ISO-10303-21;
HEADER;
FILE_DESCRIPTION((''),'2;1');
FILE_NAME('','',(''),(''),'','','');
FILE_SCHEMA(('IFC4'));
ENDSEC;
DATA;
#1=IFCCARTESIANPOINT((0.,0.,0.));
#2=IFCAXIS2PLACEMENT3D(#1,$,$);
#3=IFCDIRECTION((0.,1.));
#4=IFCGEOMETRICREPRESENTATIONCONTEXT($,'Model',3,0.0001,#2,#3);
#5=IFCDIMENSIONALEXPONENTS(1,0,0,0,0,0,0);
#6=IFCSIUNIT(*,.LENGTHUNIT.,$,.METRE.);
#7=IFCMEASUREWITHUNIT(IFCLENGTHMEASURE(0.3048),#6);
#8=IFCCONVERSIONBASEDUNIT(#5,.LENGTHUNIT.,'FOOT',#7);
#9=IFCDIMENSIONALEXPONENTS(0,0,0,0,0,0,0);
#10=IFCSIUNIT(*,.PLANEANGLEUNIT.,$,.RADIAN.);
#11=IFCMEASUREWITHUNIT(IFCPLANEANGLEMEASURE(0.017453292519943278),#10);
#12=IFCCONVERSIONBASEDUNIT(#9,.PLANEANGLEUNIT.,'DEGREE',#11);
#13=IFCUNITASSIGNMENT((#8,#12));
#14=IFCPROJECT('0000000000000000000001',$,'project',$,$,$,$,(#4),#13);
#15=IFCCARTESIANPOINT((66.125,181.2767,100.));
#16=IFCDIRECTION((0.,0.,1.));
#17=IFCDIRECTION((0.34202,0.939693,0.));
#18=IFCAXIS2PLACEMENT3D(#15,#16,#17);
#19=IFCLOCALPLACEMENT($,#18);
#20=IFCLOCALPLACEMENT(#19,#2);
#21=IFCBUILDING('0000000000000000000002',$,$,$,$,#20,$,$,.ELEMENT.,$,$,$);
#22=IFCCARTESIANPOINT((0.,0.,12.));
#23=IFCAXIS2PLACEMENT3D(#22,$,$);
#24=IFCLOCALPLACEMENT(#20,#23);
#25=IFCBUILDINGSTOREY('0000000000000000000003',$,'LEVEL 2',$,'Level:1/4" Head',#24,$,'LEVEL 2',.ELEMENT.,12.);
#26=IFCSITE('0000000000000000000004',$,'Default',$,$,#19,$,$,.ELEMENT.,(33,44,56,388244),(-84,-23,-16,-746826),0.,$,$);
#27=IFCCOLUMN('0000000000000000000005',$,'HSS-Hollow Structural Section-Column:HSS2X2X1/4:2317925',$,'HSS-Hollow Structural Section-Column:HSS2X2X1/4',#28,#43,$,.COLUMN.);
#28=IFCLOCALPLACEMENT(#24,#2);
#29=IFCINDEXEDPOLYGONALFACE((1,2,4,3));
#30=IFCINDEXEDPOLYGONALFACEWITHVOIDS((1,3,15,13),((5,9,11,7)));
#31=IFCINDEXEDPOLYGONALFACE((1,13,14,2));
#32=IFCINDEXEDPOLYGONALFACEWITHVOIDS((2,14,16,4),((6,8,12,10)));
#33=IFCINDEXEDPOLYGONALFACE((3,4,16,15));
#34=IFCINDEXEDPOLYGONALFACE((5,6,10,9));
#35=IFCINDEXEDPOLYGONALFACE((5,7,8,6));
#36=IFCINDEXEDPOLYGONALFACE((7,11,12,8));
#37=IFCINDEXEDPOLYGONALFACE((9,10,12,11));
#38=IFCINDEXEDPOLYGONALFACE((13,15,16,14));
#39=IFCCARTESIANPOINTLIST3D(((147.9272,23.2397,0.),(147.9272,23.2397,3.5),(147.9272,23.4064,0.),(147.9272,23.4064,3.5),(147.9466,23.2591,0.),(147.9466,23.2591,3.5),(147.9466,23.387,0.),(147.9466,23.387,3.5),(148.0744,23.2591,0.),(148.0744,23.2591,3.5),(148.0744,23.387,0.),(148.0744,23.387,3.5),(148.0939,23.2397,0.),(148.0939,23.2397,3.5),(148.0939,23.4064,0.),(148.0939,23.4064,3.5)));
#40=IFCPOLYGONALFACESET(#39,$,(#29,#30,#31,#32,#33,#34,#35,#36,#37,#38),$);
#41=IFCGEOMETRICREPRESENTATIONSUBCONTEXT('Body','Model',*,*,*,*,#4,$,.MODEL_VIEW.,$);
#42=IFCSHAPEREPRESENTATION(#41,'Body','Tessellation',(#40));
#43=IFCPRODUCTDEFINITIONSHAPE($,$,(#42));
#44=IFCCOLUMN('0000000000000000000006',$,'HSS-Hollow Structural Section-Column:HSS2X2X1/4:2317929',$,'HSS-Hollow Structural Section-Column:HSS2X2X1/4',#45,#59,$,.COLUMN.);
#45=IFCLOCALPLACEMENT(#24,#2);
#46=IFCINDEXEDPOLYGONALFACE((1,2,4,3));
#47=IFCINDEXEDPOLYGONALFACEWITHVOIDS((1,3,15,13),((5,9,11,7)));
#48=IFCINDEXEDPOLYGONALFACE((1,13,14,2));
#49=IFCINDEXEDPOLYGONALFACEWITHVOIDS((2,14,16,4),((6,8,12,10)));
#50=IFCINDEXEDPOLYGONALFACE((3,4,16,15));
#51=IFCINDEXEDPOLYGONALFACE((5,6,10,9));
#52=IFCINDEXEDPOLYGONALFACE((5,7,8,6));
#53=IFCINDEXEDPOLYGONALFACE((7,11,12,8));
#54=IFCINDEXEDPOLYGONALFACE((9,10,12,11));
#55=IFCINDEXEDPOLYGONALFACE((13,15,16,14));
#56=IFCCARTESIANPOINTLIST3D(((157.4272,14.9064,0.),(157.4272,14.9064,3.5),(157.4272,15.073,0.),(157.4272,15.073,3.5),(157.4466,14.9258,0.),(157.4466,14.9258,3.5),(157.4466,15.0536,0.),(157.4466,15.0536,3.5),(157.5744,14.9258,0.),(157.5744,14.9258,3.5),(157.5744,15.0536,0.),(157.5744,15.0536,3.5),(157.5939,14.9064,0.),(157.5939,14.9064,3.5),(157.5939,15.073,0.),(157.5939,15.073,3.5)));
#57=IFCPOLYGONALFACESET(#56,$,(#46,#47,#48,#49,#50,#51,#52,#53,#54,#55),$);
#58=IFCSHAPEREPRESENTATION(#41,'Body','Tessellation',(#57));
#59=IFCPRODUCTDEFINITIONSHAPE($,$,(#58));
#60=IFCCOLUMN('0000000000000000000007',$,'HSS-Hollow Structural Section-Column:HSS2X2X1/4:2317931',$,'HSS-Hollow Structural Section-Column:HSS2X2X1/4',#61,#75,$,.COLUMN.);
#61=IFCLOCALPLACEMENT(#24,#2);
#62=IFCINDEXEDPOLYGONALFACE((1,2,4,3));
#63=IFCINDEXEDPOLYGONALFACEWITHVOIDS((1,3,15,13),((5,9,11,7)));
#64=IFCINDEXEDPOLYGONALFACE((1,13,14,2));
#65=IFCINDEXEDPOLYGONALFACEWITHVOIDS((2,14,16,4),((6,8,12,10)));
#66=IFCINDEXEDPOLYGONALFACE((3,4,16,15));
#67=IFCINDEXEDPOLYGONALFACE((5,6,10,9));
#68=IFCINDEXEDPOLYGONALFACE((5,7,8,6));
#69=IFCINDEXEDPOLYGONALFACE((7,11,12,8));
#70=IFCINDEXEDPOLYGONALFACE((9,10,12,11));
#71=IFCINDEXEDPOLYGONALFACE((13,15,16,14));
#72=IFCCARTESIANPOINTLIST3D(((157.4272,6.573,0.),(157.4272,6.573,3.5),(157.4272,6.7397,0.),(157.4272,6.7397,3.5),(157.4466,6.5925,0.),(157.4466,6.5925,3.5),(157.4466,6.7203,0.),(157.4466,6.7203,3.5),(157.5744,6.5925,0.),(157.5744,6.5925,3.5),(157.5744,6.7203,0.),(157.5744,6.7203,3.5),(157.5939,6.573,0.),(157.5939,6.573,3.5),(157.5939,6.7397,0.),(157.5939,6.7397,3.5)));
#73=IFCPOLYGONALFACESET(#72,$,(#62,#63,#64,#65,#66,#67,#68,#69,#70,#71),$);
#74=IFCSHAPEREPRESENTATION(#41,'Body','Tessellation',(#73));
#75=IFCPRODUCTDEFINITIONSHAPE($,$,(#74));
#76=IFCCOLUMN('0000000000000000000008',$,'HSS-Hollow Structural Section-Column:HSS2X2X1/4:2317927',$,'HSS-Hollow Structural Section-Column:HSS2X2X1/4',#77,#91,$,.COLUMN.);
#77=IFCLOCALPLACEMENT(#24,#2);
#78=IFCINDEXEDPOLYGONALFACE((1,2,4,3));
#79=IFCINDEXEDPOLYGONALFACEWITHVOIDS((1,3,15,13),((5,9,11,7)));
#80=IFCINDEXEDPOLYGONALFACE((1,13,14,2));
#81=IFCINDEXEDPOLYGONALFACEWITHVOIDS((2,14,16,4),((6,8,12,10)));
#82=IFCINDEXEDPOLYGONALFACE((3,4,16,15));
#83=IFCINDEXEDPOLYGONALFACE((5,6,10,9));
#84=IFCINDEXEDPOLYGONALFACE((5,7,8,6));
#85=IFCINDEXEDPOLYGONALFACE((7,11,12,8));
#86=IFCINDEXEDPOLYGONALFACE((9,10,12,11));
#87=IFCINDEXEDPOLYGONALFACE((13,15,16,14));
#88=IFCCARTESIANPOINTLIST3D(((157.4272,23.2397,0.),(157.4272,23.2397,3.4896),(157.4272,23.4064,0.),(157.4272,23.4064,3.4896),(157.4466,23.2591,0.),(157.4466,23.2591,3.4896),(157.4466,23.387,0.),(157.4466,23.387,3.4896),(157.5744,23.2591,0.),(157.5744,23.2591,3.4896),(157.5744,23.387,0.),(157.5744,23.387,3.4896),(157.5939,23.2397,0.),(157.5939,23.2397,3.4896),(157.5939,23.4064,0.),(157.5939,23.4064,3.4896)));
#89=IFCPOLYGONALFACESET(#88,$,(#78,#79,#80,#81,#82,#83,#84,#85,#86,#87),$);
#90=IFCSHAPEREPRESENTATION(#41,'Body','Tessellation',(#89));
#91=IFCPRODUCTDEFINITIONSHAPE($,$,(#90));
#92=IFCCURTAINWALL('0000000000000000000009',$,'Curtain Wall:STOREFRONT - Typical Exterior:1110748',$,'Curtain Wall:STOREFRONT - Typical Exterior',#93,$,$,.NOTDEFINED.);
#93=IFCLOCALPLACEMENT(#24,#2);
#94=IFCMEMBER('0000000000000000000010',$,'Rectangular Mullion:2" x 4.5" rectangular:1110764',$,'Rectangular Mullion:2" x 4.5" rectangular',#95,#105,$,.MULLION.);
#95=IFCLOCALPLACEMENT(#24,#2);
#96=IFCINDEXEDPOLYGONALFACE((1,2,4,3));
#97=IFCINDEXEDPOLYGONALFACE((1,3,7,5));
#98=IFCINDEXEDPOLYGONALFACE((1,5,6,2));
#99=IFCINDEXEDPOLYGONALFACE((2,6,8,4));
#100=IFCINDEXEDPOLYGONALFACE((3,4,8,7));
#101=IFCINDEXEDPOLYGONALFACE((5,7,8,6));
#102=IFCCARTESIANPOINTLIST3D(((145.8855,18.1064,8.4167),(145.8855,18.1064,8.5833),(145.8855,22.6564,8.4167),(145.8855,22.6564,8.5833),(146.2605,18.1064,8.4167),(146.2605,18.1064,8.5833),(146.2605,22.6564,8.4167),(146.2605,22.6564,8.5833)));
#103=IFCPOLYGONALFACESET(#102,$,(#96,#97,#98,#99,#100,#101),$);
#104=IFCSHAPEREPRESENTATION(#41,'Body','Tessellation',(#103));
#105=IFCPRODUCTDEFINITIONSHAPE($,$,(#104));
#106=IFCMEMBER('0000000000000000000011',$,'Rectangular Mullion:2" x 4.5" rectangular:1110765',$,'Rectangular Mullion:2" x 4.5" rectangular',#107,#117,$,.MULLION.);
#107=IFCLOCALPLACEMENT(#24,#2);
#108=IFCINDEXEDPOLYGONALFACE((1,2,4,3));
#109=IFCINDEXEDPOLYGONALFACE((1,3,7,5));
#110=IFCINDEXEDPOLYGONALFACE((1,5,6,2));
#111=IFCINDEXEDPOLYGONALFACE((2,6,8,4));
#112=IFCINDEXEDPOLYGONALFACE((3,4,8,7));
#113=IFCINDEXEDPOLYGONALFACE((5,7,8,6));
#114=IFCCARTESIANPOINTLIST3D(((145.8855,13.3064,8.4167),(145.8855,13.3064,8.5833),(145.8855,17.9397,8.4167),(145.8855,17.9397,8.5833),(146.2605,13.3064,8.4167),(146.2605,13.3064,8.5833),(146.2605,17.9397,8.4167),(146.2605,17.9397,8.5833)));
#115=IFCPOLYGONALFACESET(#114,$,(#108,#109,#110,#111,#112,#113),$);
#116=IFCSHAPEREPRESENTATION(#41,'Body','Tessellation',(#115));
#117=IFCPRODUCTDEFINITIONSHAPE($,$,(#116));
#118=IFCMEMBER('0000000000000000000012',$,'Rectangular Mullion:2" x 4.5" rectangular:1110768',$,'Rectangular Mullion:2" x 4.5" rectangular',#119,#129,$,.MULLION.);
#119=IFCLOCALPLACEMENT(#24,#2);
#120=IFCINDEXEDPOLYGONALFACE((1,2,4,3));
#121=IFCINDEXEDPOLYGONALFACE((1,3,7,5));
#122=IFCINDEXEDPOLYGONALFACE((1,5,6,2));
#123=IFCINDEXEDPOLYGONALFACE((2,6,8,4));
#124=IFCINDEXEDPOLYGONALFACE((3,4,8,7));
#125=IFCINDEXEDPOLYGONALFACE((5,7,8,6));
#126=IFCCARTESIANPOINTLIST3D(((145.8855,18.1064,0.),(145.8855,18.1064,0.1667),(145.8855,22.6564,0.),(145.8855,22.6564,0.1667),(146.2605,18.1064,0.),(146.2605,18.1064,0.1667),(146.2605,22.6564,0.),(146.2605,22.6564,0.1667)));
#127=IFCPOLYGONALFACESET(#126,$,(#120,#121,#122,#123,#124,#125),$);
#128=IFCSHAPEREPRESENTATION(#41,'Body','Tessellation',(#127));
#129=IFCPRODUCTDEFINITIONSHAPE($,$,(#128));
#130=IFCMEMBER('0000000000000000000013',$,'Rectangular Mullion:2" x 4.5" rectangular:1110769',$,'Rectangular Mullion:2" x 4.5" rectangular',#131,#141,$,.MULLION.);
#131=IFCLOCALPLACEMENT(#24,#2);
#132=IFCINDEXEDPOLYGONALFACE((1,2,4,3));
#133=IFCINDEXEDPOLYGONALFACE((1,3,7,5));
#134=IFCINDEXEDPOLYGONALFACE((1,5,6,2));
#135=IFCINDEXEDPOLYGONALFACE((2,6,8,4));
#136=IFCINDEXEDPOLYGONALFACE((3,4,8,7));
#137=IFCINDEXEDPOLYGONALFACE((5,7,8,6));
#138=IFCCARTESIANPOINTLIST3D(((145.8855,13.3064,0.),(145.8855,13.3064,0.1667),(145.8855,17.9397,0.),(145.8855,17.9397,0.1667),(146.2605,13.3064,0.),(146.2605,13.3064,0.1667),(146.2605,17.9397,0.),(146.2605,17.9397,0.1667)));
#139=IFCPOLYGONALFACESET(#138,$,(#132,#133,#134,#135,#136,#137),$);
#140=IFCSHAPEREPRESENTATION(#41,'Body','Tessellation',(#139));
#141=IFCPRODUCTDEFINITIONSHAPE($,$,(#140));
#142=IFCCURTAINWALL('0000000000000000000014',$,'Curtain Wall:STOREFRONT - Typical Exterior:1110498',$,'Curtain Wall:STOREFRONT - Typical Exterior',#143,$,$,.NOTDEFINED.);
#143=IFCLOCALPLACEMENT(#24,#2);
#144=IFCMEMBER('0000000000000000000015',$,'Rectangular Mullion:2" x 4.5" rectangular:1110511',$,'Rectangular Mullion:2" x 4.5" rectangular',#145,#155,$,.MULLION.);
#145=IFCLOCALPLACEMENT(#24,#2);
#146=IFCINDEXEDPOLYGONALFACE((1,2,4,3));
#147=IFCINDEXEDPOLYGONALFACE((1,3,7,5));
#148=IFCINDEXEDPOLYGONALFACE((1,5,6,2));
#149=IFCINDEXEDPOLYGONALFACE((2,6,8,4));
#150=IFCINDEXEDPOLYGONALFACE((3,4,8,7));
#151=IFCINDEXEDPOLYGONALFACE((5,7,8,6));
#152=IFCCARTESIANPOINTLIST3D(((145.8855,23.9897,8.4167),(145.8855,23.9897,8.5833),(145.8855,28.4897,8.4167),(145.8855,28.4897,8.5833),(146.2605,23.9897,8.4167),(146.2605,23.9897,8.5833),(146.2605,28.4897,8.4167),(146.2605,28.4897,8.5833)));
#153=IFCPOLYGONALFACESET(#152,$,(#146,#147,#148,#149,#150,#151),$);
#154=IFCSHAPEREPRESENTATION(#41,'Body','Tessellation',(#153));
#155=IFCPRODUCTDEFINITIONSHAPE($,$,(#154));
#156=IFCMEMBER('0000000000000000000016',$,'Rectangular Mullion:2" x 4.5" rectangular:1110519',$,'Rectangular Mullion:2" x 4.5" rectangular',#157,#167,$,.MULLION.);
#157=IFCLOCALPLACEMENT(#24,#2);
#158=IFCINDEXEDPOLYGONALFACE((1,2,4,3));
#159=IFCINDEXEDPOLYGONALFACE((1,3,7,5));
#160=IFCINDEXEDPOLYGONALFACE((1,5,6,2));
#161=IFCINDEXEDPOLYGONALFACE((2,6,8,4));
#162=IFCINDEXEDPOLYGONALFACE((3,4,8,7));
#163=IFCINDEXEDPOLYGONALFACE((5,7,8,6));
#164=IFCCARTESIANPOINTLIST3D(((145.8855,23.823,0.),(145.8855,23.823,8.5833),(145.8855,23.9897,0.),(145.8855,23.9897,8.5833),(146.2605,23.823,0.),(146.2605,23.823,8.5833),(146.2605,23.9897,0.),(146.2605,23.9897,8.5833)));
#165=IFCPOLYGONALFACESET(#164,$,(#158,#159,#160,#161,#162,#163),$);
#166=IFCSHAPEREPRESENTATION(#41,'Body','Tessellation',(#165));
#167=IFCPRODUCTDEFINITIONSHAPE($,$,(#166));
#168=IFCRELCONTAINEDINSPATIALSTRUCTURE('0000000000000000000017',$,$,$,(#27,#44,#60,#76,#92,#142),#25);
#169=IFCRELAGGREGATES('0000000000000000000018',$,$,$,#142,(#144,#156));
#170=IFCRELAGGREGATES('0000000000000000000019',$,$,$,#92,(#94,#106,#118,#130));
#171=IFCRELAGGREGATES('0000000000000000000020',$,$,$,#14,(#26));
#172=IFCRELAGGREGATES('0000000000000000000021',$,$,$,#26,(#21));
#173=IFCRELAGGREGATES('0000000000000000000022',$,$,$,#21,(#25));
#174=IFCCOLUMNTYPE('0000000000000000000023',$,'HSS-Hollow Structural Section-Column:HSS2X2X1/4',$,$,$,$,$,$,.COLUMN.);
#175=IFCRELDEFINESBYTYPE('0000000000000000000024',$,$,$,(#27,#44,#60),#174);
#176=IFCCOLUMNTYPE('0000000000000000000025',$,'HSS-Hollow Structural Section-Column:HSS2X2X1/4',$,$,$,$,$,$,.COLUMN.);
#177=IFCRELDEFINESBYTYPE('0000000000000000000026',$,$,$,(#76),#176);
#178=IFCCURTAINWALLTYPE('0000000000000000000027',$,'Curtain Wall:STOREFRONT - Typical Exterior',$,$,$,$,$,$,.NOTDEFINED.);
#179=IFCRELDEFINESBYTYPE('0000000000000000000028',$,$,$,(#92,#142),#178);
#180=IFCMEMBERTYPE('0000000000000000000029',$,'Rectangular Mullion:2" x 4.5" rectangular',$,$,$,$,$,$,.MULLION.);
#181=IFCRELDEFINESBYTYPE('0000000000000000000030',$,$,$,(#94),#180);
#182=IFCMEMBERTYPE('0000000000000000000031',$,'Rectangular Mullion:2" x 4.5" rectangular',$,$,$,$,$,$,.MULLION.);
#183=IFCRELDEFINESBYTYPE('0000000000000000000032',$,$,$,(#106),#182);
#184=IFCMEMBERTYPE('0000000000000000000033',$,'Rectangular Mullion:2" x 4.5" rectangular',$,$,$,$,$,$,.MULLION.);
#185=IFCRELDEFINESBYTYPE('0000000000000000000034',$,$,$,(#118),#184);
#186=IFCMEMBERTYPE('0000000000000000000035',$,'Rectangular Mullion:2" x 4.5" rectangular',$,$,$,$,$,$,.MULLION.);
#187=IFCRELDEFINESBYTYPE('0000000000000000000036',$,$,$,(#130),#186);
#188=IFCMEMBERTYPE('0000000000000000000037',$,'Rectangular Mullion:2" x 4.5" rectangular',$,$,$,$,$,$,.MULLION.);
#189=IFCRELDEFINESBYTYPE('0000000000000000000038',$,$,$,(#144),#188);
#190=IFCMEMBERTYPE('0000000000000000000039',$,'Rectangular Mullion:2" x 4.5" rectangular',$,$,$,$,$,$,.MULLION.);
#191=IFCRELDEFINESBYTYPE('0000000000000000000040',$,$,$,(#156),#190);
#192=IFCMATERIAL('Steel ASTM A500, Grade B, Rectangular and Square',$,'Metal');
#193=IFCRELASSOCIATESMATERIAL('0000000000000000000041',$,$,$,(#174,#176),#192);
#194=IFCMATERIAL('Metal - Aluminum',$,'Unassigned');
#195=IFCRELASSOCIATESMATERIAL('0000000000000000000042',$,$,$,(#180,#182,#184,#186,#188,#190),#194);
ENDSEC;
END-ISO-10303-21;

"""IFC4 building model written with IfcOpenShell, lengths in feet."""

from ifc_helpers import new_model, entity, si_unit, converted_unit, direction, frame, origin, origin_2d_with_axis, place, context, subcontext, project, spatial, polyline, rectangle, outline, extrude, source, transform, mapped, material, material_profile, profile_set, type_object, type_shapes, element, aggregate, save


model = new_model("IFC4")

# Units and contexts
model_context = context("Model", 3, precision=0.0001, world=origin(), true_north=direction((0.0, 1.0)))
body_context = subcontext(model_context, "Body", "Model", "MODEL_VIEW")
ifc_project = project(units=[converted_unit("LENGTHUNIT", "FOOT", entity("IfcLengthMeasure", 0.3048), si_unit("LENGTHUNIT", "METRE"), dimensions=[1, 0, 0, 0, 0, 0, 0]), converted_unit("PLANEANGLEUNIT", "DEGREE", entity("IfcPlaneAngleMeasure", 0.017453292519943278), si_unit("PLANEANGLEUNIT", "RADIAN"), dimensions=[0, 0, 0, 0, 0, 0, 0])], contexts=[model_context])

# Site, building, storey
site_placement = place(None, frame((66.125, 181.2767, 100.0), z_axis=(0.0, 0.0, 1.0), x_axis=(0.34202, 0.939693, 0.0)))
site = spatial("IfcSite", under=ifc_project, at=site_placement, Name="Default", CompositionType="ELEMENT", RefLatitude=(33, 44, 56, 388244), RefLongitude=(-84, -23, -16, -746826), RefElevation=0.0)
building_placement = place(site_placement, origin())
building = spatial("IfcBuilding", under=site, at=building_placement, CompositionType="ELEMENT")
storey_placement = place(building_placement, frame((0.0, 0.0, 12.0)))
storey = spatial("IfcBuildingStorey", under=building, at=storey_placement, Name="LEVEL 2", ObjectType="Level:1/4\" Head", LongName="LEVEL 2", CompositionType="ELEMENT", Elevation=12.0)

# Columns
ifc_material_1 = material(Name="Steel ASTM A500, Grade B, Rectangular and Square", Category="Metal")
ifc_material_profile_1 = material_profile(ifc_material_1, outline(polyline([(-0.0833, -0.0833), (0.0833, -0.0833), (0.0833, 0.0833), (-0.0833, 0.0833), (-0.0833, -0.0833)]), holes=[polyline([(-0.0639, -0.0639), (-0.0639, 0.0639), (0.0639, 0.0639), (0.0639, -0.0639), (-0.0639, -0.0639)])]), Name="HSS2X2X1/4")
ifc_profile_set_1 = profile_set([ifc_material_profile_1], Name="HSS2X2X1/4")
column_type_1 = type_object("IfcColumnType", Name="HSS-Hollow Structural Section-Column:HSS2X2X1/4", PredefinedType="COLUMN", material=ifc_profile_set_1)
shared_shape_1 = source(origin(), body_context, "Body", "SweptSolid", [
    extrude(outline(polyline([(-0.0833, -0.0833), (0.0833, -0.0833), (0.0833, 0.0833), (-0.0833, 0.0833), (-0.0833, -0.0833)]), holes=[polyline([(-0.0639, -0.0639), (-0.0639, 0.0639), (0.0639, 0.0639), (0.0639, -0.0639), (-0.0639, -0.0639)])]), frame((0.0, 0.0, 12.0), z_axis=(0.0, 0.0, 1.0), x_axis=(-1.0, 0.0, 0.0)), (0.0, 0.0, 1.0), 3.5),
])
type_shapes(column_type_1, [shared_shape_1])
for number, where, name in (
    (1, (148.0105, 23.323, -12.0), "HSS-Hollow Structural Section-Column:HSS2X2X1/4:2317925"),
    (2, (157.5105, 14.9897, -12.0), "HSS-Hollow Structural Section-Column:HSS2X2X1/4:2317929"),
    (3, (157.5105, 6.6564, -12.0), "HSS-Hollow Structural Section-Column:HSS2X2X1/4:2317931"),
):
    element("IfcColumn", number, at=place(storey_placement, frame(where)), inside=storey, type_object=column_type_1, Name=name, ObjectType="HSS-Hollow Structural Section-Column:HSS2X2X1/4", PredefinedType="COLUMN", context=body_context, shape_type="MappedRepresentation", body=[
        mapped(shared_shape_1, transform((0.0, 0.0, 0.0), scale=1.0)),
    ])
column_type_2 = type_object("IfcColumnType", Name="HSS-Hollow Structural Section-Column:HSS2X2X1/4", PredefinedType="COLUMN", material=ifc_profile_set_1)
shared_shape_2 = source(origin(), body_context, "Body", "SweptSolid", [
    extrude(outline(polyline([(-0.0833, -0.0833), (0.0833, -0.0833), (0.0833, 0.0833), (-0.0833, 0.0833), (-0.0833, -0.0833)]), holes=[polyline([(-0.0639, -0.0639), (-0.0639, 0.0639), (0.0639, 0.0639), (0.0639, -0.0639), (-0.0639, -0.0639)])]), frame((0.0, 0.0, 12.0), z_axis=(0.0, 0.0, 1.0), x_axis=(-1.0, 0.0, 0.0)), (0.0, 0.0, 1.0), 3.4896),
])
type_shapes(column_type_2, [shared_shape_2])
column_placement = place(storey_placement, frame((157.5105, 23.323, -12.0)))
element("IfcColumn", 4, at=column_placement, inside=storey, type_object=column_type_2, Name="HSS-Hollow Structural Section-Column:HSS2X2X1/4:2317927", ObjectType="HSS-Hollow Structural Section-Column:HSS2X2X1/4", PredefinedType="COLUMN", context=body_context, shape_type="MappedRepresentation", body=[
    mapped(shared_shape_2, transform((0.0, 0.0, 0.0), scale=1.0)),
])

# Curtain walls, members
curtain_wall_type = type_object("IfcCurtainWallType", Name="Curtain Wall:STOREFRONT - Typical Exterior", PredefinedType="NOTDEFINED")
curtain_wall_1_placement = place(storey_placement, frame((0.0, 0.0, -12.0)))
curtain_wall_1 = element("IfcCurtainWall", 5, at=curtain_wall_1_placement, inside=storey, type_object=curtain_wall_type, Name="Curtain Wall:STOREFRONT - Typical Exterior:1110748", ObjectType="Curtain Wall:STOREFRONT - Typical Exterior", PredefinedType="NOTDEFINED")
ifc_material_2 = material(Name="Metal - Aluminum", Category="Unassigned")
ifc_material_profile_2 = material_profile(ifc_material_2, rectangle(XDim=0.1667, YDim=0.375, at=origin_2d_with_axis()), Name="2\" x 4.5\" rectangular")
ifc_profile_set_2 = profile_set([ifc_material_profile_2], Name="2\" x 4.5\" rectangular")
member_type_1 = type_object("IfcMemberType", Name="Rectangular Mullion:2\" x 4.5\" rectangular", PredefinedType="MULLION", material=ifc_profile_set_2)
shared_shape_3 = source(origin(), body_context, "Body", "SweptSolid", [
    extrude(rectangle(XDim=0.1667, YDim=0.375, at=origin_2d_with_axis()), frame((-0.0833, 0.0, -4.55), z_axis=(0.0, 0.0, 1.0), x_axis=(-1.0, 0.0, 0.0)), (0.0, 0.0, 1.0), 4.55),
])
type_shapes(member_type_1, [shared_shape_3])
member_1_placement = place(curtain_wall_1_placement, frame((146.073, 18.1064, 20.5833), z_axis=(0.0, -1.0, 0.0), x_axis=(0.0, 0.0, 1.0)))
member_1 = element("IfcMember", 6, at=member_1_placement, type_object=member_type_1, Name="Rectangular Mullion:2\" x 4.5\" rectangular:1110764", ObjectType="Rectangular Mullion:2\" x 4.5\" rectangular", PredefinedType="MULLION", context=body_context, shape_type="MappedRepresentation", body=[
    mapped(shared_shape_3, transform((0.0, 0.0, 0.0), scale=1.0)),
])
member_type_2 = type_object("IfcMemberType", Name="Rectangular Mullion:2\" x 4.5\" rectangular", PredefinedType="MULLION", material=ifc_profile_set_2)
shared_shape_4 = source(origin(), body_context, "Body", "SweptSolid", [
    extrude(rectangle(XDim=0.1667, YDim=0.375, at=origin_2d_with_axis()), frame((-0.0833, 0.0, -4.6333), z_axis=(0.0, 0.0, 1.0), x_axis=(-1.0, 0.0, 0.0)), (0.0, 0.0, 1.0), 4.6333),
])
type_shapes(member_type_2, [shared_shape_4])
member_2_placement = place(curtain_wall_1_placement, frame((146.073, 13.3064, 20.5833), z_axis=(0.0, -1.0, 0.0), x_axis=(0.0, 0.0, 1.0)))
member_2 = element("IfcMember", 7, at=member_2_placement, type_object=member_type_2, Name="Rectangular Mullion:2\" x 4.5\" rectangular:1110765", ObjectType="Rectangular Mullion:2\" x 4.5\" rectangular", PredefinedType="MULLION", context=body_context, shape_type="MappedRepresentation", body=[
    mapped(shared_shape_4, transform((0.0, 0.0, 0.0), scale=1.0)),
])
member_type_3 = type_object("IfcMemberType", Name="Rectangular Mullion:2\" x 4.5\" rectangular", PredefinedType="MULLION", material=ifc_profile_set_2)
shared_shape_5 = source(origin(), body_context, "Body", "SweptSolid", [
    extrude(rectangle(XDim=0.1667, YDim=0.375, at=origin_2d_with_axis()), frame((-0.0833, 0.0, -4.55), z_axis=(0.0, 0.0, 1.0), x_axis=(-1.0, 0.0, 0.0)), (0.0, 0.0, 1.0), 4.55),
])
type_shapes(member_type_3, [shared_shape_5])
member_3_placement = place(curtain_wall_1_placement, frame((146.073, 22.6564, 12.0), z_axis=(0.0, 1.0, 0.0), x_axis=(0.0, 0.0, -1.0)))
member_3 = element("IfcMember", 8, at=member_3_placement, type_object=member_type_3, Name="Rectangular Mullion:2\" x 4.5\" rectangular:1110768", ObjectType="Rectangular Mullion:2\" x 4.5\" rectangular", PredefinedType="MULLION", context=body_context, shape_type="MappedRepresentation", body=[
    mapped(shared_shape_5, transform((0.0, 0.0, 0.0), scale=1.0)),
])
member_type_4 = type_object("IfcMemberType", Name="Rectangular Mullion:2\" x 4.5\" rectangular", PredefinedType="MULLION", material=ifc_profile_set_2)
shared_shape_6 = source(origin(), body_context, "Body", "SweptSolid", [
    extrude(rectangle(XDim=0.1667, YDim=0.375, at=origin_2d_with_axis()), frame((-0.0833, 0.0, -4.6333), z_axis=(0.0, 0.0, 1.0), x_axis=(-1.0, 0.0, 0.0)), (0.0, 0.0, 1.0), 4.6333),
])
type_shapes(member_type_4, [shared_shape_6])
member_4_placement = place(curtain_wall_1_placement, frame((146.073, 17.9397, 12.0), z_axis=(0.0, 1.0, 0.0), x_axis=(0.0, 0.0, -1.0)))
member_4 = element("IfcMember", 9, at=member_4_placement, type_object=member_type_4, Name="Rectangular Mullion:2\" x 4.5\" rectangular:1110769", ObjectType="Rectangular Mullion:2\" x 4.5\" rectangular", PredefinedType="MULLION", context=body_context, shape_type="MappedRepresentation", body=[
    mapped(shared_shape_6, transform((0.0, 0.0, 0.0), scale=1.0)),
])
curtain_wall_2_placement = place(storey_placement, frame((0.0, 0.0, -12.0)))
curtain_wall_2 = element("IfcCurtainWall", 10, at=curtain_wall_2_placement, inside=storey, type_object=curtain_wall_type, Name="Curtain Wall:STOREFRONT - Typical Exterior:1110498", ObjectType="Curtain Wall:STOREFRONT - Typical Exterior", PredefinedType="NOTDEFINED")
member_type_5 = type_object("IfcMemberType", Name="Rectangular Mullion:2\" x 4.5\" rectangular", PredefinedType="MULLION", material=ifc_profile_set_2)
shared_shape_7 = source(origin(), body_context, "Body", "SweptSolid", [
    extrude(rectangle(XDim=0.1667, YDim=0.375, at=origin_2d_with_axis()), frame((-0.0833, 0.0, -4.5), z_axis=(0.0, 0.0, 1.0), x_axis=(-1.0, 0.0, 0.0)), (0.0, 0.0, 1.0), 4.5),
])
type_shapes(member_type_5, [shared_shape_7])
member_5_placement = place(curtain_wall_2_placement, frame((146.073, 23.9897, 20.5833), z_axis=(0.0, -1.0, 0.0), x_axis=(0.0, 0.0, 1.0)))
member_5 = element("IfcMember", 11, at=member_5_placement, type_object=member_type_5, Name="Rectangular Mullion:2\" x 4.5\" rectangular:1110511", ObjectType="Rectangular Mullion:2\" x 4.5\" rectangular", PredefinedType="MULLION", context=body_context, shape_type="MappedRepresentation", body=[
    mapped(shared_shape_7, transform((0.0, 0.0, 0.0), scale=1.0)),
])
member_type_6 = type_object("IfcMemberType", Name="Rectangular Mullion:2\" x 4.5\" rectangular", PredefinedType="MULLION", material=ifc_profile_set_2)
shared_shape_8 = source(origin(), body_context, "Body", "SweptSolid", [
    extrude(rectangle(XDim=0.1667, YDim=0.375, at=origin_2d_with_axis()), frame((-0.0833, 0.0, -8.5833), z_axis=(0.0, 0.0, 1.0), x_axis=(-1.0, 0.0, 0.0)), (0.0, 0.0, 1.0), 8.5833),
])
type_shapes(member_type_6, [shared_shape_8])
member_6_placement = place(curtain_wall_2_placement, frame((146.073, 23.823, 12.0), z_axis=(0.0, 0.0, -1.0), x_axis=(0.0, -1.0, 0.0)))
member_6 = element("IfcMember", 12, at=member_6_placement, type_object=member_type_6, Name="Rectangular Mullion:2\" x 4.5\" rectangular:1110519", ObjectType="Rectangular Mullion:2\" x 4.5\" rectangular", PredefinedType="MULLION", context=body_context, shape_type="MappedRepresentation", body=[
    mapped(shared_shape_8, transform((0.0, 0.0, 0.0), scale=1.0)),
])

aggregate(curtain_wall_2, [member_5, member_6])
aggregate(curtain_wall_1, [member_1, member_2, member_3, member_4])

save(model, "model.ifc")
